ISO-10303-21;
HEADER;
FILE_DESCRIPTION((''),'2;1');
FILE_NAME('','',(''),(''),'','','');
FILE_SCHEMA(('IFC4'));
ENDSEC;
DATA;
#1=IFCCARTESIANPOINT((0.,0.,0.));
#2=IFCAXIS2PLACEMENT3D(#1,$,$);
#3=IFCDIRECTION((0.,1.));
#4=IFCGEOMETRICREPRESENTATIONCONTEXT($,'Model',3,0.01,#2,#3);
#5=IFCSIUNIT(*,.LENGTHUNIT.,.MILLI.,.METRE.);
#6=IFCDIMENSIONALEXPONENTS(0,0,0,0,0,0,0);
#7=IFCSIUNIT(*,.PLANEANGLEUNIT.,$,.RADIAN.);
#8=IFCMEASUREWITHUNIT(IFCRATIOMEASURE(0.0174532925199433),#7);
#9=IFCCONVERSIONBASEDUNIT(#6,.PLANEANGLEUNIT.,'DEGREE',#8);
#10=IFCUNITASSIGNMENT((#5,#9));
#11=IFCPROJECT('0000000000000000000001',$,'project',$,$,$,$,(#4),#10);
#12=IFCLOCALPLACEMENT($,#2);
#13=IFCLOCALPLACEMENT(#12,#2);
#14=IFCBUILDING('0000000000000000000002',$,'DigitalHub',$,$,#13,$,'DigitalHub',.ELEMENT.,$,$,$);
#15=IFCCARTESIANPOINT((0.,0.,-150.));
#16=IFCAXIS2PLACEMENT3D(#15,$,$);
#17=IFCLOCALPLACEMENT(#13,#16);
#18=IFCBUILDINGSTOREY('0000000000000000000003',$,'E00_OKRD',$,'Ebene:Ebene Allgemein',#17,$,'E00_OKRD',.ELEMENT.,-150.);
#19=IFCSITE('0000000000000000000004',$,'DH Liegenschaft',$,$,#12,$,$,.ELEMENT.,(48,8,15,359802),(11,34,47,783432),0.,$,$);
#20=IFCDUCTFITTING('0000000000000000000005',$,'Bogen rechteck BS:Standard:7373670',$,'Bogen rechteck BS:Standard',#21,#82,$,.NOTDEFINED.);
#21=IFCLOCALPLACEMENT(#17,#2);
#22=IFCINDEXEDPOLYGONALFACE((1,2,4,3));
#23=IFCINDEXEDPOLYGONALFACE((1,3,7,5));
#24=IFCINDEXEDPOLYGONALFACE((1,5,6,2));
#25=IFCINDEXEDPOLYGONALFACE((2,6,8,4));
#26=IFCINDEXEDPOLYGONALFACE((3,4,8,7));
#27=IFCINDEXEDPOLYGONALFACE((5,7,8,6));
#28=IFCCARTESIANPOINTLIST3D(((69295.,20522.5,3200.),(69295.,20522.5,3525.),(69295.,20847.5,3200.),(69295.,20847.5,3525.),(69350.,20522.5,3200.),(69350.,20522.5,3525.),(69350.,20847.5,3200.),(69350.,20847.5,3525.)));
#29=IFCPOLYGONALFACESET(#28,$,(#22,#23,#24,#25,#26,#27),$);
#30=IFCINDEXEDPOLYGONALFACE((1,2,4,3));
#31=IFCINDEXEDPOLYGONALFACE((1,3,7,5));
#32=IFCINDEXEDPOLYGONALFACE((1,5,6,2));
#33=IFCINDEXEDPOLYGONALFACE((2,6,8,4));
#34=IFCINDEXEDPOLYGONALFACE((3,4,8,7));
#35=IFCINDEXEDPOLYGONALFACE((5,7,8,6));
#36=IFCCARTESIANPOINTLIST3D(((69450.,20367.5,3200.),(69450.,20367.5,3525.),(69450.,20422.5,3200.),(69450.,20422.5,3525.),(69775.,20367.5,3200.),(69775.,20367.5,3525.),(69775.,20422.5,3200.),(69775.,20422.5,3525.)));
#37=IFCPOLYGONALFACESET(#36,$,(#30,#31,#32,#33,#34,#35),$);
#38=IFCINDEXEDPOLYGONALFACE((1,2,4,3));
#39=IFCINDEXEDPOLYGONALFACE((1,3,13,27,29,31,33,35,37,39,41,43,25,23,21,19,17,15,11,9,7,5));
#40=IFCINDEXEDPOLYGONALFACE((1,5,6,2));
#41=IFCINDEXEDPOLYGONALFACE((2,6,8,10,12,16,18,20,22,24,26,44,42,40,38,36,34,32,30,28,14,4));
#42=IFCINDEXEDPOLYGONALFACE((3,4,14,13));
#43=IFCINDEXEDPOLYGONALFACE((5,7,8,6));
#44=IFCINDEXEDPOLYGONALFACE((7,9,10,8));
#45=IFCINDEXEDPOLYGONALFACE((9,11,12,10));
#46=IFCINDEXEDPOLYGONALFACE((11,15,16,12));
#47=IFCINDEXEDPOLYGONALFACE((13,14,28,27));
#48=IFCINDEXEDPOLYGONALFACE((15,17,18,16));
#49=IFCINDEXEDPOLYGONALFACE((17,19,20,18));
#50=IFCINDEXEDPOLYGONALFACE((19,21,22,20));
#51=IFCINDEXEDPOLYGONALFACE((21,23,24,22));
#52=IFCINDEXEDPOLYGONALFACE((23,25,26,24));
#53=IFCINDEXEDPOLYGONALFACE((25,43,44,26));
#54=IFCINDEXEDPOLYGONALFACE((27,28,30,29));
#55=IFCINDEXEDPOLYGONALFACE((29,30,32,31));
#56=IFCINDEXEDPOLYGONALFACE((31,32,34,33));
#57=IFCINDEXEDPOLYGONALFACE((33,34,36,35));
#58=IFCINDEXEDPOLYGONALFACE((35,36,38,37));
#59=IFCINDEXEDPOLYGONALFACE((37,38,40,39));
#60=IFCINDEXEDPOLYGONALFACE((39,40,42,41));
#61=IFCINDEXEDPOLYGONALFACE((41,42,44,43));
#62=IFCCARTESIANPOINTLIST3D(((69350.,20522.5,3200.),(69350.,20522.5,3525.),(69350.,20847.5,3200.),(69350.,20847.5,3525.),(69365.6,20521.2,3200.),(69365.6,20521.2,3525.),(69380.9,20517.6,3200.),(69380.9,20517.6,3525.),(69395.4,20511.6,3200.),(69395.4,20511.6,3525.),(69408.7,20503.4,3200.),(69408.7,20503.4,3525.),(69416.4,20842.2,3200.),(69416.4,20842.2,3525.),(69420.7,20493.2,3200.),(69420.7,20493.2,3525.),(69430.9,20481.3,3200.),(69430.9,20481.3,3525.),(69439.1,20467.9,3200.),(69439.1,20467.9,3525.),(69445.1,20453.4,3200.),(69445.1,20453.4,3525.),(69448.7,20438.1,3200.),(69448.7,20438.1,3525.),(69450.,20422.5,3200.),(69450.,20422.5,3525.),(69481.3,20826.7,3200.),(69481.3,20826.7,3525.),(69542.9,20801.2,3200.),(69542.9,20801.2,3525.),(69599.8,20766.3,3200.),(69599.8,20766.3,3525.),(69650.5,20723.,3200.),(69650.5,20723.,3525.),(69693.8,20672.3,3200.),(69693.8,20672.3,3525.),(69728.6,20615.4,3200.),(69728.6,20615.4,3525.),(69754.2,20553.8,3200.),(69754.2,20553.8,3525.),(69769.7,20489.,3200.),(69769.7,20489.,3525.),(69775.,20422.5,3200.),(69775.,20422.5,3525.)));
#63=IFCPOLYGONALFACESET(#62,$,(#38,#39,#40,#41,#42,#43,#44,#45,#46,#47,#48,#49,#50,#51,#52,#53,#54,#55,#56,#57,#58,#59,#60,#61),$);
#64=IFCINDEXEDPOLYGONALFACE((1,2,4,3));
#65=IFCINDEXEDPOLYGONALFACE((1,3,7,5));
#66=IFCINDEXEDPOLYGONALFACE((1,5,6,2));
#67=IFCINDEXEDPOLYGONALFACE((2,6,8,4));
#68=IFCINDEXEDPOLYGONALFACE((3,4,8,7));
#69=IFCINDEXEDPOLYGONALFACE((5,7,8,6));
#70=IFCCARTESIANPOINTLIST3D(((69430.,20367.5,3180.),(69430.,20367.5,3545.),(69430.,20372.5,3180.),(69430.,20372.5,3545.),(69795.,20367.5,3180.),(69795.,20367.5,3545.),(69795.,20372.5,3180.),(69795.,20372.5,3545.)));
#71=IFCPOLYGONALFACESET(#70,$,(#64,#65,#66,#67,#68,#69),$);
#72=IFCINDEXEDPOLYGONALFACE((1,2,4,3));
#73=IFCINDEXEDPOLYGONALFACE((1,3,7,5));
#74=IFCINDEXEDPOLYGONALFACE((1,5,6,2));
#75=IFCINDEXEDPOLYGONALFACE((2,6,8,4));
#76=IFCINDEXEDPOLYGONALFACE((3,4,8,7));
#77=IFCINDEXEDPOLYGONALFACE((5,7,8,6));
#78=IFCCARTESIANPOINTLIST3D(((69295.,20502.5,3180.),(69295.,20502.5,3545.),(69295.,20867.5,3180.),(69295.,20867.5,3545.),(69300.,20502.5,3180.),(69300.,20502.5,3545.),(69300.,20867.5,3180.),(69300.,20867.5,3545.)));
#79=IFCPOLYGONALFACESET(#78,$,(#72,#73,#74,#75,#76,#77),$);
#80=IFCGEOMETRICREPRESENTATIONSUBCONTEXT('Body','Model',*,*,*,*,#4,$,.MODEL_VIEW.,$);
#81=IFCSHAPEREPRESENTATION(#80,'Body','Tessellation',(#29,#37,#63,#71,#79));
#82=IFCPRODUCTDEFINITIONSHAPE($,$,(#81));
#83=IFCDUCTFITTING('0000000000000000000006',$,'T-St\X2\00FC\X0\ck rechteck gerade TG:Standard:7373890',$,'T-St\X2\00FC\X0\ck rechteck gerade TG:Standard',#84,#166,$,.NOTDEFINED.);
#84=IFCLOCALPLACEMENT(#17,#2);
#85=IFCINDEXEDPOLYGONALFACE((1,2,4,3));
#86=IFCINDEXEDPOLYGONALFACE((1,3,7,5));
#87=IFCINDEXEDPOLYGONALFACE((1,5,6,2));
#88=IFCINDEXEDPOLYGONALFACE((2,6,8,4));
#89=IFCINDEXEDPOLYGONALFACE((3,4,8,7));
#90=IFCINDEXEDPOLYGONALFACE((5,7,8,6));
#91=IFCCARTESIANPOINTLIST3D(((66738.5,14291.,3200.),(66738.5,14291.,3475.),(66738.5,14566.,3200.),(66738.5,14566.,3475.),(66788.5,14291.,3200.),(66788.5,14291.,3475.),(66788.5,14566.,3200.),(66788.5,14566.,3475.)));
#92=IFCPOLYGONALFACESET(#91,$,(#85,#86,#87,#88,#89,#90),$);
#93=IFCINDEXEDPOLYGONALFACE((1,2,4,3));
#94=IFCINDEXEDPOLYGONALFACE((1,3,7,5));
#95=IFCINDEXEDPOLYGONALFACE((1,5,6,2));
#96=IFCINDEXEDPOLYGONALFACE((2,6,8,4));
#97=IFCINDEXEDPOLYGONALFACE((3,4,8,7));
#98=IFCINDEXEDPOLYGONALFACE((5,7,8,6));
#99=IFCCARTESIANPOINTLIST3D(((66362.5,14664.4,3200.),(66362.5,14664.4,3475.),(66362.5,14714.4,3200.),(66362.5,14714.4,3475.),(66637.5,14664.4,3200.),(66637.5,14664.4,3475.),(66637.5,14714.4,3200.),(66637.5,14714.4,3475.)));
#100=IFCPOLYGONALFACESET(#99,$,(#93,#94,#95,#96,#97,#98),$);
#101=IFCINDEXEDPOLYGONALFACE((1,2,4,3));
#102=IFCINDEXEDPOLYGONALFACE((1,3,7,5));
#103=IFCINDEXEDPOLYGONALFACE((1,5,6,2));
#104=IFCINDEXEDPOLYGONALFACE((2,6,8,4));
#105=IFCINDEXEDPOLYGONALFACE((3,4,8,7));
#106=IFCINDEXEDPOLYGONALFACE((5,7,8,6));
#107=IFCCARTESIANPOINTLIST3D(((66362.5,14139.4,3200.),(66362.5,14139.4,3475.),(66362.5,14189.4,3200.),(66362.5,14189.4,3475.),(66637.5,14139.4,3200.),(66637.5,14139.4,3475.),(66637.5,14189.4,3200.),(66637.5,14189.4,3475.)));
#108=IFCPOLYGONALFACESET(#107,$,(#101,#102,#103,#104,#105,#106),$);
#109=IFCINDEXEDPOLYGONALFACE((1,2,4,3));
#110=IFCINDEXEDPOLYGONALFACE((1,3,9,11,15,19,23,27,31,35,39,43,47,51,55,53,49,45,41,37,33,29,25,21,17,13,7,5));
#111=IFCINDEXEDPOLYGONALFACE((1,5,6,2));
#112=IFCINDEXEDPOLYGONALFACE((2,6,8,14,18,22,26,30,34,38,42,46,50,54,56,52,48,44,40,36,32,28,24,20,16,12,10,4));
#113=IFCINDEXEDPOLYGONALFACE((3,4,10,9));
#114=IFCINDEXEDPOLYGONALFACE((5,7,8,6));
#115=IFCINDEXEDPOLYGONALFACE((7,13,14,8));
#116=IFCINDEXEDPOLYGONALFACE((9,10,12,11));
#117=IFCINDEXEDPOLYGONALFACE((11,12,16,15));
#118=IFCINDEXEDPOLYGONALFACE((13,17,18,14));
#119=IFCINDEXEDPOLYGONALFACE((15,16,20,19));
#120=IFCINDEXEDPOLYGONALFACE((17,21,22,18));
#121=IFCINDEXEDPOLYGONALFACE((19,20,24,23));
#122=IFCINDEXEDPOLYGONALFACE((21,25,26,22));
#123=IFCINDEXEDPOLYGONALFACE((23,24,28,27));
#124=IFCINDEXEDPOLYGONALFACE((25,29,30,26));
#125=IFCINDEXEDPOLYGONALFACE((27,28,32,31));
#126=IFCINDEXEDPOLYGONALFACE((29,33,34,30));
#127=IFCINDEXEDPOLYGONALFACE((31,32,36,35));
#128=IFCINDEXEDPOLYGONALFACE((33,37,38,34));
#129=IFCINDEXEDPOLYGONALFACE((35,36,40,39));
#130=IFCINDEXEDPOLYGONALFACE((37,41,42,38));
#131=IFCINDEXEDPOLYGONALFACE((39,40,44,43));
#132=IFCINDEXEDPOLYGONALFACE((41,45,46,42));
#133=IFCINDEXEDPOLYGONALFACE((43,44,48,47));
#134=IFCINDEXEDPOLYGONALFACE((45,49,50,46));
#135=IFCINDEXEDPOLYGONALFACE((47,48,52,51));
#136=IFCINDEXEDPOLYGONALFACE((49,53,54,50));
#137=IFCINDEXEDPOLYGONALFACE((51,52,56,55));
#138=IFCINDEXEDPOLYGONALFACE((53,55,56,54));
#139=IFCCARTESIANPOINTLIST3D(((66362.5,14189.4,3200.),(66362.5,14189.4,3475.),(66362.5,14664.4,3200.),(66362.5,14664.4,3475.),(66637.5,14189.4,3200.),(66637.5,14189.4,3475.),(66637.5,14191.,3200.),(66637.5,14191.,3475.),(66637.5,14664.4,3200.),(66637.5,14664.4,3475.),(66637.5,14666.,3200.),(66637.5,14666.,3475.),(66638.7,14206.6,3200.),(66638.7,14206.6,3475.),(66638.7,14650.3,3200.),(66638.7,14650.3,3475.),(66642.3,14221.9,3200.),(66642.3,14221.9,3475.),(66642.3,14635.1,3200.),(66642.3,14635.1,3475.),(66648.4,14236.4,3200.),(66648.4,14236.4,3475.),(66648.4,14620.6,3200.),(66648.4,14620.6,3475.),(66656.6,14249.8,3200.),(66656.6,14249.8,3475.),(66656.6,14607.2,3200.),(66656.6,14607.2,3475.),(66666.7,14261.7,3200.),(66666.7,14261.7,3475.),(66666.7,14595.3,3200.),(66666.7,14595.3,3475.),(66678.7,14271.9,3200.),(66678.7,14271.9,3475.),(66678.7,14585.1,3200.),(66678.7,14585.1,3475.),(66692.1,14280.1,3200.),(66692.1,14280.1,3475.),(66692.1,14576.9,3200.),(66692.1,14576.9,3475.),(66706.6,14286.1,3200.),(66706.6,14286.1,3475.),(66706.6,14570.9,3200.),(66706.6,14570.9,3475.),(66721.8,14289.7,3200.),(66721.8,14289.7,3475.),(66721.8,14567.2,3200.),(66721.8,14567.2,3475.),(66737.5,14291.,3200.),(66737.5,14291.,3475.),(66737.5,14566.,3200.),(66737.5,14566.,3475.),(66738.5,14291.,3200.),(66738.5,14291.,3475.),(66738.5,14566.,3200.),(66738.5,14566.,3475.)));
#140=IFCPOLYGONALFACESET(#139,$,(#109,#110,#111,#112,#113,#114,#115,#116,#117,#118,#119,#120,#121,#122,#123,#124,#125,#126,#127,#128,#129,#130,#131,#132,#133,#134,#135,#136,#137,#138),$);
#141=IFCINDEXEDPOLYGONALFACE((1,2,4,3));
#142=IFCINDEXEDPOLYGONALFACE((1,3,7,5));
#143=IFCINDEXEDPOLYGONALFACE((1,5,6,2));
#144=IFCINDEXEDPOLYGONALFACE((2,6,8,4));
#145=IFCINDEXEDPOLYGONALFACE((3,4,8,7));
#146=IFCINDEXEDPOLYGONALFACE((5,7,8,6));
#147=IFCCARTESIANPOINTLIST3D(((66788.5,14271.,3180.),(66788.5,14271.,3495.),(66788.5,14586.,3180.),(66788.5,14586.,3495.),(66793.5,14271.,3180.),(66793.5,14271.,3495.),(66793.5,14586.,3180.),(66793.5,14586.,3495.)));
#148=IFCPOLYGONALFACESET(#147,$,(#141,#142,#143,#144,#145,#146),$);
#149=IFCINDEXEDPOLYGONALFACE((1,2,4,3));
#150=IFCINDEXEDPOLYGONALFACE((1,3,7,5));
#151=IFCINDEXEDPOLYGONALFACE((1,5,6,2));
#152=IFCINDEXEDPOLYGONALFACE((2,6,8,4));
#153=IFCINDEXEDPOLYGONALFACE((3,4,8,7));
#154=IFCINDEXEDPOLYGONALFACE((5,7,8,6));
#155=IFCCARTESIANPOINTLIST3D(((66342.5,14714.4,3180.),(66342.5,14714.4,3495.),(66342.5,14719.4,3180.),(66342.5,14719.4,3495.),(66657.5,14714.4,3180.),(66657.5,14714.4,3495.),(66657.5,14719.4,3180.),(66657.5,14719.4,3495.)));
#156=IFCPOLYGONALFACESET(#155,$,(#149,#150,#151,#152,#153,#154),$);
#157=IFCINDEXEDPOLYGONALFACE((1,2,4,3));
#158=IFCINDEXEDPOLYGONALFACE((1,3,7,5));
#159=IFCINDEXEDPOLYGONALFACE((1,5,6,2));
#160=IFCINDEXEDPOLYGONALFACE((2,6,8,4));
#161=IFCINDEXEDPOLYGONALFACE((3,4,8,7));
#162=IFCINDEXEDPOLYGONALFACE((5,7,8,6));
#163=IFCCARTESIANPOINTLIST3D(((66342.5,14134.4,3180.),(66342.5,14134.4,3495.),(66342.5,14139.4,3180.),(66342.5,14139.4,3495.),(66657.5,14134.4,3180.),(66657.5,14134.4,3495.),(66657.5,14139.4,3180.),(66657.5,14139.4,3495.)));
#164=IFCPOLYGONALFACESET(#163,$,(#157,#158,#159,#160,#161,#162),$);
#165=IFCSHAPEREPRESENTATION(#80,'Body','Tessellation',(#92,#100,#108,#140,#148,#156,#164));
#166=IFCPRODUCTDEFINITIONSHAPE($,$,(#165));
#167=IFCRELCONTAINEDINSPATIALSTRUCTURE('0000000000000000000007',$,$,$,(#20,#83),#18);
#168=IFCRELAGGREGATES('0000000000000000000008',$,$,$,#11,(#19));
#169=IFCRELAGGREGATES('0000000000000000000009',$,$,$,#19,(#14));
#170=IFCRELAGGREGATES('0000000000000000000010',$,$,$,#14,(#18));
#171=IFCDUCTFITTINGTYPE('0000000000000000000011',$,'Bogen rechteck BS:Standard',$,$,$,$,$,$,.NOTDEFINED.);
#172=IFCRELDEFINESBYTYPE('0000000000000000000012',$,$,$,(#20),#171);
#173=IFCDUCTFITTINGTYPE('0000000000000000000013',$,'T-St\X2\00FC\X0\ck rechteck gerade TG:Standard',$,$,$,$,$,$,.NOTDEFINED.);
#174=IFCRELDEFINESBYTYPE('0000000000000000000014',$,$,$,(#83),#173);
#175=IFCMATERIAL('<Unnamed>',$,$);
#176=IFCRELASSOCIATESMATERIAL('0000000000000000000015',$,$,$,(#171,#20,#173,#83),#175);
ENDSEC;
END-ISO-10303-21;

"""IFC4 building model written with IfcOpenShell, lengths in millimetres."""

from ifc_helpers import new_model, entity, si_unit, converted_unit, direction, frame, origin, place, context, subcontext, project, spatial, indexed_curve, outline, extrude, source, transform, mapped, material, type_object, type_shapes, element, save


model = new_model("IFC4")

# Units and contexts
model_context = context("Model", 3, precision=0.01, world=origin(), true_north=direction((0.0, 1.0)))
body_context = subcontext(model_context, "Body", "Model", "MODEL_VIEW")
ifc_project = project(units=[si_unit("LENGTHUNIT", "METRE", prefix="MILLI"), converted_unit("PLANEANGLEUNIT", "DEGREE", entity("IfcRatioMeasure", 0.0174532925199433), si_unit("PLANEANGLEUNIT", "RADIAN"), dimensions=[0, 0, 0, 0, 0, 0, 0])], contexts=[model_context])

# Site, building, storey
site_placement = place(None, origin())
site = spatial("IfcSite", under=ifc_project, at=site_placement, Name="DH Liegenschaft", CompositionType="ELEMENT", RefLatitude=(48, 8, 15, 359802), RefLongitude=(11, 34, 47, 783432), RefElevation=0.0)
building_placement = place(site_placement, origin())
building = spatial("IfcBuilding", under=site, at=building_placement, Name="DigitalHub", LongName="DigitalHub", CompositionType="ELEMENT")
storey_placement = place(building_placement, frame((0.0, 0.0, -150.0)))
storey = spatial("IfcBuildingStorey", under=building, at=storey_placement, Name="E00_OKRD", ObjectType="Ebene:Ebene Allgemein", LongName="E00_OKRD", CompositionType="ELEMENT", Elevation=-150.0)

# Shared definitions
ifc_material_1 = material(Name="<Unnamed>")

# Duct fittings
duct_fitting_type_1 = type_object("IfcDuctFittingType", Name="Bogen rechteck BS:Standard", PredefinedType="NOTDEFINED", material=ifc_material_1)
shared_shape_1 = source(origin(), body_context, "Body", "SweptSolid", [
    extrude(outline(indexed_curve([(-27.5, -162.5), (27.5, -162.5), (27.5, 162.5), (-27.5, 162.5), (-27.5, -162.5)], self_intersect=False)), frame((0.0, 290.0, -162.5), z_axis=(0.0, 0.0, 1.0), x_axis=(0.0, 1.0, 0.0)), (0.0, 0.0, 1.0), 325.0),
    extrude(outline(indexed_curve([(-162.5, -27.5), (162.5, -27.5), (162.5, 27.5), (-162.5, 27.5), (-162.5, -27.5)], self_intersect=False)), frame((-290.0, 0.0, -162.5), z_axis=(0.0, 0.0, 1.0), x_axis=(0.0, -1.0, 0.0)), (0.0, 0.0, 1.0), 325.0),
    extrude(outline(indexed_curve([(-293.8, -131.2), (31.2, -131.2), (32.5, -115.6), (36.1, -100.3), (42.1, -85.9), (50.3, -72.5), (60.5, -60.5), (72.5, -50.3), (85.9, -42.1), (100.3, -36.1), (115.6, -32.5), (131.2, -31.2), (131.2, 293.8), (64.8, 288.5), (-0.1, 272.9), (-61.7, 247.4), (-118.6, 212.6), (-169.3, 169.3), (-212.6, 118.6), (-247.4, 61.7), (-272.9, 0.1), (-288.5, -64.8), (-293.8, -131.2)], self_intersect=False)), frame((-131.2, 131.3, -162.5), z_axis=(0.0, 0.0, 1.0), x_axis=(-1.0, 0.0, 0.0)), (0.0, 0.0, 1.0), 325.0),
    extrude(outline(indexed_curve([(-2.5, -182.5), (2.5, -182.5), (2.5, 182.5), (-2.5, 182.5), (-2.5, -182.5)], self_intersect=False)), frame((-315.0, 0.0, -182.5)), (0.0, 0.0, 1.0), 365.0),
    extrude(outline(indexed_curve([(-2.5, -182.5), (2.5, -182.5), (2.5, 182.5), (-2.5, 182.5), (-2.5, -182.5)], self_intersect=False)), frame((0.0, 315.0, -182.5), z_axis=(0.0, 0.0, 1.0), x_axis=(0.0, 1.0, 0.0)), (0.0, 0.0, 1.0), 365.0),
])
type_shapes(duct_fitting_type_1, [shared_shape_1])
duct_fitting_1_placement = place(storey_placement, frame((69612.5, 20685.0, 3362.5), z_axis=(0.0, 0.0, 1.0), x_axis=(0.0, 1.0, 0.0)))
element("IfcDuctFitting", 1, at=duct_fitting_1_placement, inside=storey, type_object=duct_fitting_type_1, material=ifc_material_1, Name="Bogen rechteck BS:Standard:7373670", ObjectType="Bogen rechteck BS:Standard", PredefinedType="NOTDEFINED", context=body_context, shape_type="MappedRepresentation", body=[
    mapped(shared_shape_1, transform((0.0, 0.0, 0.0), scale=1.0)),
])
duct_fitting_type_2 = type_object("IfcDuctFittingType", Name="T-Stück rechteck gerade TG:Standard", PredefinedType="NOTDEFINED", material=ifc_material_1)
shared_shape_2 = source(origin(), body_context, "Body", "SweptSolid", [
    extrude(outline(indexed_curve([(-25.0, -137.5), (25.0, -137.5), (25.0, 137.5), (-25.0, 137.5), (-25.0, -137.5)], self_intersect=False)), frame((0.0, -263.5, -137.5), z_axis=(0.0, 0.0, 1.0), x_axis=(0.0, -1.0, 0.0)), (0.0, 0.0, 1.0), 275.0),
    extrude(outline(indexed_curve([(-25.0, -137.5), (25.0, -137.5), (25.0, 137.5), (-25.0, 137.5), (-25.0, -137.5)], self_intersect=False)), frame((260.9, 0.0, -137.5), z_axis=(0.0, 0.0, 1.0), x_axis=(-1.0, 0.0, 0.0)), (0.0, 0.0, 1.0), 275.0),
    extrude(outline(indexed_curve([(-25.0, -137.5), (25.0, -137.5), (25.0, 137.5), (-25.0, 137.5), (-25.0, -137.5)], self_intersect=False)), frame((-264.1, 0.0, -137.5)), (0.0, 0.0, 1.0), 275.0),
    extrude(outline(indexed_curve([(-238.1, -14.8), (-222.5, -16.0), (-207.2, -19.7), (-192.7, -25.7), (-179.4, -33.9), (-167.4, -44.1), (-157.2, -56.0), (-149.0, -69.4), (-143.0, -83.9), (-139.4, -99.2), (-138.1, -114.8), (-138.1, -115.8), (136.9, -115.8), (136.9, -114.8), (138.1, -99.2), (141.8, -83.9), (147.8, -69.4), (156.0, -56.0), (166.1, -44.1), (178.1, -33.9), (191.5, -25.7), (206.0, -19.7), (221.2, -16.0), (236.9, -14.8), (238.5, -14.8), (238.5, 260.2), (-236.5, 260.2), (-236.5, -14.8), (-238.1, -14.8)], self_intersect=False)), frame((-0.6, -122.7, -137.5), z_axis=(0.0, 0.0, -1.0), x_axis=(-1.0, 0.0, 0.0)), (0.0, 0.0, -1.0), 275.0),
    extrude(outline(indexed_curve([(-2.5, -157.5), (2.5, -157.5), (2.5, 157.5), (-2.5, 157.5), (-2.5, -157.5)], self_intersect=False)), frame((0.0, -291.0, -157.5), z_axis=(0.0, 0.0, 1.0), x_axis=(0.0, 1.0, 0.0)), (0.0, 0.0, 1.0), 315.0),
    extrude(outline(indexed_curve([(-2.5, -157.5), (2.5, -157.5), (2.5, 157.5), (-2.5, 157.5), (-2.5, -157.5)], self_intersect=False)), frame((288.4, 0.0, -157.5), z_axis=(0.0, 0.0, 1.0), x_axis=(-1.0, 0.0, 0.0)), (0.0, 0.0, 1.0), 315.0),
    extrude(outline(indexed_curve([(-2.5, -157.5), (2.5, -157.5), (2.5, 157.5), (-2.5, 157.5), (-2.5, -157.5)], self_intersect=False)), frame((-291.6, 0.0, -157.5), z_axis=(0.0, 0.0, 1.0), x_axis=(-1.0, 0.0, 0.0)), (0.0, 0.0, 1.0), 315.0),
])
type_shapes(duct_fitting_type_2, [shared_shape_2])
duct_fitting_2_placement = place(storey_placement, frame((66500.0, 14428.5, 3337.5), z_axis=(0.0, 0.0, 1.0), x_axis=(0.0, 1.0, 0.0)))
element("IfcDuctFitting", 2, at=duct_fitting_2_placement, inside=storey, type_object=duct_fitting_type_2, material=ifc_material_1, Name="T-Stück rechteck gerade TG:Standard:7373890", ObjectType="T-Stück rechteck gerade TG:Standard", PredefinedType="NOTDEFINED", context=body_context, shape_type="MappedRepresentation", body=[
    mapped(shared_shape_2, transform((0.0, 0.0, 0.0), scale=1.0)),
])

save(model, "model.ifc")
